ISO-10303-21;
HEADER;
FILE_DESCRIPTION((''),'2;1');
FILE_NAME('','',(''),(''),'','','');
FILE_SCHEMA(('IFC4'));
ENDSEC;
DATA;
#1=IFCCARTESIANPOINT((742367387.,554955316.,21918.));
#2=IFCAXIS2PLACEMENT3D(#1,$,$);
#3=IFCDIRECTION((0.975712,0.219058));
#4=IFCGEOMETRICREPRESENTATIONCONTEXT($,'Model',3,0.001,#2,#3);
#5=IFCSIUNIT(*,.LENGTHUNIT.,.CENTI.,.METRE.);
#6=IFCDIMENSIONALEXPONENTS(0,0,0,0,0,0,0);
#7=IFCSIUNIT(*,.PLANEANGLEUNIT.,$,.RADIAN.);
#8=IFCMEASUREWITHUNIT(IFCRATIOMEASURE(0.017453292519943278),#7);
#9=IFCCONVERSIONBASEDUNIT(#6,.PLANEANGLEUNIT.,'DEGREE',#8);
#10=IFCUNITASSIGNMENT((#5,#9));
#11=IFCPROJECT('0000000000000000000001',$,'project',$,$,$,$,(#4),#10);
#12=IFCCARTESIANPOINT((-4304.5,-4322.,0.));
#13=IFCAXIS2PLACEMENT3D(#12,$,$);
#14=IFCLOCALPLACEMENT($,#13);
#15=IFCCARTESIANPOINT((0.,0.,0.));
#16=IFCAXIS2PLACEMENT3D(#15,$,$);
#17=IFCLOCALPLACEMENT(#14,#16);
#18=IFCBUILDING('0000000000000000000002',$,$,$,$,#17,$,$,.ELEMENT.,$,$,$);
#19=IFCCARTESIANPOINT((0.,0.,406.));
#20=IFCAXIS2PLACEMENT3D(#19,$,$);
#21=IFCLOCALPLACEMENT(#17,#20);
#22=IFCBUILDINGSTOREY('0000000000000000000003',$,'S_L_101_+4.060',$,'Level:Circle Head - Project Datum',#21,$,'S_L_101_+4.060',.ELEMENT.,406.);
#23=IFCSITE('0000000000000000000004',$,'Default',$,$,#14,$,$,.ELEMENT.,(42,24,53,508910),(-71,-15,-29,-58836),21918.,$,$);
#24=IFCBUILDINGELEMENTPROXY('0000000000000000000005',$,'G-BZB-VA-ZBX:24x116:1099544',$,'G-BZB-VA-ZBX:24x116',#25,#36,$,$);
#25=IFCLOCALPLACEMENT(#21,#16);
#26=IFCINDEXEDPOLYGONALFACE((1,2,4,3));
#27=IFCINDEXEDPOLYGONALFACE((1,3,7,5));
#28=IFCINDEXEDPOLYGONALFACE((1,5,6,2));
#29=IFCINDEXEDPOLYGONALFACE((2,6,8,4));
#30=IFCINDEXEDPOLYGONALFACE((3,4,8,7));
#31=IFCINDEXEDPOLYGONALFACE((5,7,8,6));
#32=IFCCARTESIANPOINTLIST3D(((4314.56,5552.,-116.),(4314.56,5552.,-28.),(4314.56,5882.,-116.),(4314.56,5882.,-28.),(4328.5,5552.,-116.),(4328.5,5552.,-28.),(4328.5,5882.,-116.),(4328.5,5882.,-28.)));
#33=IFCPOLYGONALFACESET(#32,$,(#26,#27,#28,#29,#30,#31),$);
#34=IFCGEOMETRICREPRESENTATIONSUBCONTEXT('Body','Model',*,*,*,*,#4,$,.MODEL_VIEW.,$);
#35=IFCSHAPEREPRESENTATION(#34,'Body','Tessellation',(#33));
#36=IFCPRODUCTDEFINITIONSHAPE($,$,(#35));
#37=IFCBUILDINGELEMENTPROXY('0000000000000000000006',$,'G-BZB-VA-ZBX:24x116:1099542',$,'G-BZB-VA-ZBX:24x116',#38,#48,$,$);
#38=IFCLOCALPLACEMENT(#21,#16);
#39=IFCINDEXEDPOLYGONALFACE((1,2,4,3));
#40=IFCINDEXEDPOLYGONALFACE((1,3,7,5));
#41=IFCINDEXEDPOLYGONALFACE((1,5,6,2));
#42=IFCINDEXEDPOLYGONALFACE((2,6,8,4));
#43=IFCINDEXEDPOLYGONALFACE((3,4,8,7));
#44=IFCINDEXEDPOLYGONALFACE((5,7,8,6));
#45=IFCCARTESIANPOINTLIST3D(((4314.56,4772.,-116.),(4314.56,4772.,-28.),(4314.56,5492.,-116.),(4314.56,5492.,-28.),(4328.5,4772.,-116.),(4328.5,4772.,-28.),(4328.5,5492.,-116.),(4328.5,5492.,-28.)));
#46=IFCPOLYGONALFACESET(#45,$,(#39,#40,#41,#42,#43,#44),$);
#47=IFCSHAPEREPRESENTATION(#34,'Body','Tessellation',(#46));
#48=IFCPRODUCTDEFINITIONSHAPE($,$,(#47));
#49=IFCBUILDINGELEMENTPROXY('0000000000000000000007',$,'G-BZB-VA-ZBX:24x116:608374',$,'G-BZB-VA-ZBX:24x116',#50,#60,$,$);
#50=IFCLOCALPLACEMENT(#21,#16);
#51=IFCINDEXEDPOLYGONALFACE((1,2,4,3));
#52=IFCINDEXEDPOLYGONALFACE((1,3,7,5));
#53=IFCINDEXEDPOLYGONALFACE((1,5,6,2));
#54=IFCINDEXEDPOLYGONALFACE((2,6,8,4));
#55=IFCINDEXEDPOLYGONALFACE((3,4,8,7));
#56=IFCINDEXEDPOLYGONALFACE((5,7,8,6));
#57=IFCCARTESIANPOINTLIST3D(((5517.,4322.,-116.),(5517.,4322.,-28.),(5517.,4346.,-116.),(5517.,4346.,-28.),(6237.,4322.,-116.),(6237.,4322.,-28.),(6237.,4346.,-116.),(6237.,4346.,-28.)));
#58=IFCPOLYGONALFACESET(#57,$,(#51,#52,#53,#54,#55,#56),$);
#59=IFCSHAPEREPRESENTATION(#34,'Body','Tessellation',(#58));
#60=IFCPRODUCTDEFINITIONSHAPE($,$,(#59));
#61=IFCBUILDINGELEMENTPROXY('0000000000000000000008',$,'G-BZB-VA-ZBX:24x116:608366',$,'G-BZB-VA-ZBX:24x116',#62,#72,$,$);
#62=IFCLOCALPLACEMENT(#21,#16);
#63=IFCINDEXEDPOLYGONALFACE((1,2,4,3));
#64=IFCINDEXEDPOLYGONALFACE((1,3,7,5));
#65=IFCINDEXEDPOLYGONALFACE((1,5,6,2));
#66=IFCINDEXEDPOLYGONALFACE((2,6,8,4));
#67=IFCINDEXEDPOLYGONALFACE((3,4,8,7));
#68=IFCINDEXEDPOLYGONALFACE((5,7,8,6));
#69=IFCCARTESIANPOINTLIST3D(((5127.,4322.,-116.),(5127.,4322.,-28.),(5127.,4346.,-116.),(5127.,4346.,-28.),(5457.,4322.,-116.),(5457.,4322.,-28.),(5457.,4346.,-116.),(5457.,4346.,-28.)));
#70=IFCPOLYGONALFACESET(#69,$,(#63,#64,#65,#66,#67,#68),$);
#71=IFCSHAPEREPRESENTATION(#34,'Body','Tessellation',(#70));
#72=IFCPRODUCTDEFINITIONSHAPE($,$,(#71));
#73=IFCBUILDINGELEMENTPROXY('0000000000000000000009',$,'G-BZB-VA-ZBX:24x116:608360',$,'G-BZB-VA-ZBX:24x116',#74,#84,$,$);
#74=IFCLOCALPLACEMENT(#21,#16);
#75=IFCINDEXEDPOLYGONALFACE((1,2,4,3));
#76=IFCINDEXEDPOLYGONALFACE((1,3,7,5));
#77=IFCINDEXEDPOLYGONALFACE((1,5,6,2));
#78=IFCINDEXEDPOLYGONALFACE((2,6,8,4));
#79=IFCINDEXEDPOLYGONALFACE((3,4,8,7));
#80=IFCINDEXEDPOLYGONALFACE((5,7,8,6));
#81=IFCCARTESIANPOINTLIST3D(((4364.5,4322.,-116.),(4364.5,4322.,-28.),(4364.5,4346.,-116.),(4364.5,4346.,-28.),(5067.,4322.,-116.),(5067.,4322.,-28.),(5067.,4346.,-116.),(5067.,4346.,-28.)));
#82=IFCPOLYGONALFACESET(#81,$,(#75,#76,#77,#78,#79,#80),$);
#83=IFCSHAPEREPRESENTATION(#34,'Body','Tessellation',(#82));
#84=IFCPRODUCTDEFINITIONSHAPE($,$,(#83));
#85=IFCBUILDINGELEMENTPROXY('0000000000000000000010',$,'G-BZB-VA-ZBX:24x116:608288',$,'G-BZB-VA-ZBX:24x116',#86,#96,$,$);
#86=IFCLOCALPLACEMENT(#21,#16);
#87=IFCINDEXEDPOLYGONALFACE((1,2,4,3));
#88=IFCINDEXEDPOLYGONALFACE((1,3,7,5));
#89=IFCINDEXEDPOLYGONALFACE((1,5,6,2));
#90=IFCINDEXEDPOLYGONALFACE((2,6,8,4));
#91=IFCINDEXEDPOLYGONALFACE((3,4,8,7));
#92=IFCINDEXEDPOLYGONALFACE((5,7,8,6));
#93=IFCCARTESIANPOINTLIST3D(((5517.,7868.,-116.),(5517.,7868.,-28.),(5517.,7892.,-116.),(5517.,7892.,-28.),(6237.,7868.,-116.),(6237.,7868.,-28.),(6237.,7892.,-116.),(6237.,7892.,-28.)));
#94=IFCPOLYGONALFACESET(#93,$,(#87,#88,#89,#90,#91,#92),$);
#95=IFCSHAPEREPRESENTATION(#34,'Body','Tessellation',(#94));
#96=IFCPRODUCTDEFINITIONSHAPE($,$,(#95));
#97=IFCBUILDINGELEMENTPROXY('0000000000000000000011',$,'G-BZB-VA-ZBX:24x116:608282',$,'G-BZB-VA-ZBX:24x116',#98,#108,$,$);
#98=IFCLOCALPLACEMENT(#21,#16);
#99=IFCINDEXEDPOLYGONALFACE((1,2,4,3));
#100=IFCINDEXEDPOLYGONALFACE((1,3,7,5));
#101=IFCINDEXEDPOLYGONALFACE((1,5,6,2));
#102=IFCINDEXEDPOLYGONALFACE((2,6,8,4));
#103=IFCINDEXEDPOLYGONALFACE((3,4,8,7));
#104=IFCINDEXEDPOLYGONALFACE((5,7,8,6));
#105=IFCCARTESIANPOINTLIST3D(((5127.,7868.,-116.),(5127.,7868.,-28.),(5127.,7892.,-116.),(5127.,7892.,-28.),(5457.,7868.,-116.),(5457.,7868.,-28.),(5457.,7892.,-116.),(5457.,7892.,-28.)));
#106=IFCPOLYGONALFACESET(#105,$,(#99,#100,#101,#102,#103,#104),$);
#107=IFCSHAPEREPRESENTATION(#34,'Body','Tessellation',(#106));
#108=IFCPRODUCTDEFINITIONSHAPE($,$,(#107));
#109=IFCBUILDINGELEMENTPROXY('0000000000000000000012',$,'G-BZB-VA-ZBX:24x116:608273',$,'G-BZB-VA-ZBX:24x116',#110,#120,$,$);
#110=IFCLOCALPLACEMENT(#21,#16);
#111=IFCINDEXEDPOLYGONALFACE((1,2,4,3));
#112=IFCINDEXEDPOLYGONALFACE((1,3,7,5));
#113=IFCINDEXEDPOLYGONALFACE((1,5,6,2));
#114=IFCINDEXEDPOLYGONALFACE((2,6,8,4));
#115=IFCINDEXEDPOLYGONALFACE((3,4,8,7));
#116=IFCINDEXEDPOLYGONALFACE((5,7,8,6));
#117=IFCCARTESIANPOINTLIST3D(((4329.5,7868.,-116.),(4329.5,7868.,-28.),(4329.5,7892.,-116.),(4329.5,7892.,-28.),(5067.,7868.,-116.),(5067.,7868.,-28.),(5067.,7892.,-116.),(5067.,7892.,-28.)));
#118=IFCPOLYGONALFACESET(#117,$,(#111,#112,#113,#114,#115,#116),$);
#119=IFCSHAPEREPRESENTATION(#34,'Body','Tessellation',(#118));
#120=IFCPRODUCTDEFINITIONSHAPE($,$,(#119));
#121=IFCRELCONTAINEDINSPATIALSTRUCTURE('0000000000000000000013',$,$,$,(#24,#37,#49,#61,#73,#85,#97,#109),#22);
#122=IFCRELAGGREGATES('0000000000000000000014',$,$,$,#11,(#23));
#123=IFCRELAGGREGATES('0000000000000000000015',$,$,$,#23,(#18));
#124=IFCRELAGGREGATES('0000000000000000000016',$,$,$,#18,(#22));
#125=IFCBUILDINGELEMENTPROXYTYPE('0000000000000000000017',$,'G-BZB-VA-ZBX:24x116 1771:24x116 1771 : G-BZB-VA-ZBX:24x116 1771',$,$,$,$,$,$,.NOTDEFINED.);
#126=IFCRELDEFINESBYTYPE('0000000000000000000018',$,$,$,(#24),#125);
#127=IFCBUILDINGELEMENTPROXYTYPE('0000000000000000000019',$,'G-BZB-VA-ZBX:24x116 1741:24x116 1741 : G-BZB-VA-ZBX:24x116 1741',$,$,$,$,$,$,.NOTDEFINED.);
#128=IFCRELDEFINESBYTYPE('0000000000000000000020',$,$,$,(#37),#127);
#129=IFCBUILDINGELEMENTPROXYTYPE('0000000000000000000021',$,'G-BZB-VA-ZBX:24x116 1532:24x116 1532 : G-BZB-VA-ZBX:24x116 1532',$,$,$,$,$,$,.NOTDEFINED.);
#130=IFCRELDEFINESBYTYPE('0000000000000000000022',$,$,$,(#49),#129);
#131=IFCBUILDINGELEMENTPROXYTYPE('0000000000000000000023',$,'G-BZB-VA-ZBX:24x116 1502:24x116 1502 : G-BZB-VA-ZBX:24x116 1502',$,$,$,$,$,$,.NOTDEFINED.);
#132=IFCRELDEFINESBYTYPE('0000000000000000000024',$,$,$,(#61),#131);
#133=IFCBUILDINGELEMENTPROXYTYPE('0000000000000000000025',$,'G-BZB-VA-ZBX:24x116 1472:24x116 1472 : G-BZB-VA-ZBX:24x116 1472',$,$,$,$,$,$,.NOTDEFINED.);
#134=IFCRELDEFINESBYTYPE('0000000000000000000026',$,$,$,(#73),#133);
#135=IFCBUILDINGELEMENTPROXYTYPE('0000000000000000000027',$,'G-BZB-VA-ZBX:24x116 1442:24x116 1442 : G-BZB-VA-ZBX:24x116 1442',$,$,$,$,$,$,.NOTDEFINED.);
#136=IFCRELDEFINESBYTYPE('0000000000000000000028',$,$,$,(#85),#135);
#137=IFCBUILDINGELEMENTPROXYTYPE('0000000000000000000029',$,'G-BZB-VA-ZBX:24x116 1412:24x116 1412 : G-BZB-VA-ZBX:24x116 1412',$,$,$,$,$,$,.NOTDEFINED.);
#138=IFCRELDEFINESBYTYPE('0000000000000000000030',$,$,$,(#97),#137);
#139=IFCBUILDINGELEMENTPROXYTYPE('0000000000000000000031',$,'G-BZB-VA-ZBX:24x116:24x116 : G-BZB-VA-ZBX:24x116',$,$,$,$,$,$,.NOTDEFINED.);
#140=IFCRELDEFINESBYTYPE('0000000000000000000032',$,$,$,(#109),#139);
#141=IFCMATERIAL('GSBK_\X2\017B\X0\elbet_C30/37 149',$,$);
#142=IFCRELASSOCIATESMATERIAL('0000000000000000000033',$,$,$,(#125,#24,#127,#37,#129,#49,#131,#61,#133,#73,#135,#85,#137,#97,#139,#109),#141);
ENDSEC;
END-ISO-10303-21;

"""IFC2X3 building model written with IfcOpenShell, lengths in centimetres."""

from ifc_helpers import new_model, entity, si_unit, converted_unit, direction, frame, frame_2d, origin, origin_2d_with_axis, place, context, subcontext, project, spatial, rectangle, extrude, source, transform, mapped, material, type_object, type_shapes, element, save


model = new_model("IFC2X3")

# Units and contexts
model_context = context("Model", 3, precision=0.001, world=frame((742367387.0, 554955316.0, 21918.0)), true_north=direction((0.975712, 0.219058)))
body_context = subcontext(model_context, "Body", "Model", "MODEL_VIEW")
ifc_project = project(units=[si_unit("LENGTHUNIT", "METRE", prefix="CENTI"), converted_unit("PLANEANGLEUNIT", "DEGREE", entity("IfcRatioMeasure", 0.017453292519943278), si_unit("PLANEANGLEUNIT", "RADIAN"), dimensions=[0, 0, 0, 0, 0, 0, 0])], contexts=[model_context])

# Site, building, storey
site_placement = place(None, frame((-4304.5, -4322.0, 0.0)))
site = spatial("IfcSite", under=ifc_project, at=site_placement, Name="Default", CompositionType="ELEMENT", RefLatitude=(42, 24, 53, 508910), RefLongitude=(-71, -15, -29, -58836), RefElevation=21918.0)
building_placement = place(site_placement, origin())
building = spatial("IfcBuilding", under=site, at=building_placement, CompositionType="ELEMENT")
storey_placement = place(building_placement, frame((0.0, 0.0, 406.0)))
storey = spatial("IfcBuildingStorey", under=building, at=storey_placement, Name="S_L_101_+4.060", ObjectType="Level:Circle Head - Project Datum", LongName="S_L_101_+4.060", CompositionType="ELEMENT", Elevation=406.0)

# Building element proxies
ifc_material_1 = material(Name="GSBK_Żelbet_C30/37 149")
building_element_proxy_type_1 = type_object("IfcBuildingElementProxyType", Name="G-BZB-VA-ZBX:24x116 1771:24x116 1771 : G-BZB-VA-ZBX:24x116 1771", PredefinedType="NOTDEFINED", material=ifc_material_1)
shared_shape_1 = source(origin(), body_context, "Body", "SweptSolid", [
    extrude(rectangle(XDim=330.0, YDim=13.94, at=origin_2d_with_axis()), frame((165.0, 6.97, 0.0), z_axis=(0.0, 0.0, 1.0), x_axis=(-1.0, 0.0, 0.0)), (0.0, 0.0, 1.0), 88.0),
])
type_shapes(building_element_proxy_type_1, [shared_shape_1])
proxy_1_placement = place(storey_placement, frame((4328.5, 5552.0, -116.0), z_axis=(0.0, 0.0, 1.0), x_axis=(0.0, 1.0, 0.0)))
element("IfcBuildingElementProxy", 1, at=proxy_1_placement, inside=storey, type_object=building_element_proxy_type_1, material=ifc_material_1, Name="G-BZB-VA-ZBX:24x116:1099544", ObjectType="G-BZB-VA-ZBX:24x116", context=body_context, shape_type="MappedRepresentation", body=[
    mapped(shared_shape_1, transform((0.0, 0.0, 0.0), scale=1.0)),
])
building_element_proxy_type_2 = type_object("IfcBuildingElementProxyType", Name="G-BZB-VA-ZBX:24x116 1741:24x116 1741 : G-BZB-VA-ZBX:24x116 1741", PredefinedType="NOTDEFINED", material=ifc_material_1)
shared_shape_2 = source(origin(), body_context, "Body", "SweptSolid", [
    extrude(rectangle(XDim=720.0, YDim=13.94, at=origin_2d_with_axis()), frame((360.0, 6.97, 0.0), z_axis=(0.0, 0.0, 1.0), x_axis=(-1.0, 0.0, 0.0)), (0.0, 0.0, 1.0), 88.0),
])
type_shapes(building_element_proxy_type_2, [shared_shape_2])
proxy_2_placement = place(storey_placement, frame((4328.5, 4772.0, -116.0), z_axis=(0.0, 0.0, 1.0), x_axis=(0.0, 1.0, 0.0)))
element("IfcBuildingElementProxy", 2, at=proxy_2_placement, inside=storey, type_object=building_element_proxy_type_2, material=ifc_material_1, Name="G-BZB-VA-ZBX:24x116:1099542", ObjectType="G-BZB-VA-ZBX:24x116", context=body_context, shape_type="MappedRepresentation", body=[
    mapped(shared_shape_2, transform((0.0, 0.0, 0.0), scale=1.0)),
])
building_element_proxy_type_3 = type_object("IfcBuildingElementProxyType", Name="G-BZB-VA-ZBX:24x116 1532:24x116 1532 : G-BZB-VA-ZBX:24x116 1532", PredefinedType="NOTDEFINED", material=ifc_material_1)
shared_shape_3 = source(origin(), body_context, "Body", "SweptSolid", [
    extrude(rectangle(XDim=720.0, YDim=24.0, at=origin_2d_with_axis()), frame((360.0, 12.0, 0.0), z_axis=(0.0, 0.0, 1.0), x_axis=(-1.0, 0.0, 0.0)), (0.0, 0.0, 1.0), 88.0),
])
type_shapes(building_element_proxy_type_3, [shared_shape_3])
proxy_3_placement = place(storey_placement, frame((5517.0, 4322.0, -116.0)))
element("IfcBuildingElementProxy", 3, at=proxy_3_placement, inside=storey, type_object=building_element_proxy_type_3, material=ifc_material_1, Name="G-BZB-VA-ZBX:24x116:608374", ObjectType="G-BZB-VA-ZBX:24x116", context=body_context, shape_type="MappedRepresentation", body=[
    mapped(shared_shape_3, transform((0.0, 0.0, 0.0), scale=1.0)),
])
building_element_proxy_type_4 = type_object("IfcBuildingElementProxyType", Name="G-BZB-VA-ZBX:24x116 1502:24x116 1502 : G-BZB-VA-ZBX:24x116 1502", PredefinedType="NOTDEFINED", material=ifc_material_1)
shared_shape_4 = source(origin(), body_context, "Body", "SweptSolid", [
    extrude(rectangle(XDim=330.0, YDim=24.0, at=origin_2d_with_axis()), frame((165.0, 12.0, 0.0), z_axis=(0.0, 0.0, 1.0), x_axis=(-1.0, 0.0, 0.0)), (0.0, 0.0, 1.0), 88.0),
])
type_shapes(building_element_proxy_type_4, [shared_shape_4])
proxy_4_placement = place(storey_placement, frame((5127.0, 4322.0, -116.0)))
element("IfcBuildingElementProxy", 4, at=proxy_4_placement, inside=storey, type_object=building_element_proxy_type_4, material=ifc_material_1, Name="G-BZB-VA-ZBX:24x116:608366", ObjectType="G-BZB-VA-ZBX:24x116", context=body_context, shape_type="MappedRepresentation", body=[
    mapped(shared_shape_4, transform((0.0, 0.0, 0.0), scale=1.0)),
])
building_element_proxy_type_5 = type_object("IfcBuildingElementProxyType", Name="G-BZB-VA-ZBX:24x116 1472:24x116 1472 : G-BZB-VA-ZBX:24x116 1472", PredefinedType="NOTDEFINED", material=ifc_material_1)
shared_shape_5 = source(origin(), body_context, "Body", "SweptSolid", [
    extrude(rectangle(XDim=702.5, YDim=24.0, at=origin_2d_with_axis()), frame((351.25, 12.0, 0.0), z_axis=(0.0, 0.0, 1.0), x_axis=(-1.0, 0.0, 0.0)), (0.0, 0.0, 1.0), 88.0),
])
type_shapes(building_element_proxy_type_5, [shared_shape_5])
proxy_5_placement = place(storey_placement, frame((4364.5, 4322.0, -116.0)))
element("IfcBuildingElementProxy", 5, at=proxy_5_placement, inside=storey, type_object=building_element_proxy_type_5, material=ifc_material_1, Name="G-BZB-VA-ZBX:24x116:608360", ObjectType="G-BZB-VA-ZBX:24x116", context=body_context, shape_type="MappedRepresentation", body=[
    mapped(shared_shape_5, transform((0.0, 0.0, 0.0), scale=1.0)),
])
building_element_proxy_type_6 = type_object("IfcBuildingElementProxyType", Name="G-BZB-VA-ZBX:24x116 1442:24x116 1442 : G-BZB-VA-ZBX:24x116 1442", PredefinedType="NOTDEFINED", material=ifc_material_1)
shared_shape_6 = source(origin(), body_context, "Body", "SweptSolid", [
    extrude(rectangle(XDim=720.0, YDim=24.0, at=frame_2d((0.0, 0.0), x_axis=(1.0, 0.0))), frame((360.0, 12.0, 0.0), z_axis=(0.0, 0.0, 1.0), x_axis=(-1.0, 0.0, 0.0)), (0.0, 0.0, 1.0), 88.0),
])
type_shapes(building_element_proxy_type_6, [shared_shape_6])
proxy_6_placement = place(storey_placement, frame((5517.0, 7868.0, -116.0)))
element("IfcBuildingElementProxy", 6, at=proxy_6_placement, inside=storey, type_object=building_element_proxy_type_6, material=ifc_material_1, Name="G-BZB-VA-ZBX:24x116:608288", ObjectType="G-BZB-VA-ZBX:24x116", context=body_context, shape_type="MappedRepresentation", body=[
    mapped(shared_shape_6, transform((0.0, 0.0, 0.0), scale=1.0)),
])
building_element_proxy_type_7 = type_object("IfcBuildingElementProxyType", Name="G-BZB-VA-ZBX:24x116 1412:24x116 1412 : G-BZB-VA-ZBX:24x116 1412", PredefinedType="NOTDEFINED", material=ifc_material_1)
shared_shape_7 = source(origin(), body_context, "Body", "SweptSolid", [
    extrude(rectangle(XDim=330.0, YDim=24.0, at=frame_2d((0.0, 0.0), x_axis=(1.0, 0.0))), frame((165.0, 12.0, 0.0), z_axis=(0.0, 0.0, 1.0), x_axis=(-1.0, 0.0, 0.0)), (0.0, 0.0, 1.0), 88.0),
])
type_shapes(building_element_proxy_type_7, [shared_shape_7])
proxy_7_placement = place(storey_placement, frame((5127.0, 7868.0, -116.0)))
element("IfcBuildingElementProxy", 7, at=proxy_7_placement, inside=storey, type_object=building_element_proxy_type_7, material=ifc_material_1, Name="G-BZB-VA-ZBX:24x116:608282", ObjectType="G-BZB-VA-ZBX:24x116", context=body_context, shape_type="MappedRepresentation", body=[
    mapped(shared_shape_7, transform((0.0, 0.0, 0.0), scale=1.0)),
])
building_element_proxy_type_8 = type_object("IfcBuildingElementProxyType", Name="G-BZB-VA-ZBX:24x116:24x116 : G-BZB-VA-ZBX:24x116", PredefinedType="NOTDEFINED", material=ifc_material_1)
shared_shape_8 = source(origin(), body_context, "Body", "SweptSolid", [
    extrude(rectangle(XDim=737.5, YDim=24.0, at=frame_2d((0.0, 0.0), x_axis=(1.0, 0.0))), frame((368.75, 12.0, 0.0), z_axis=(0.0, 0.0, 1.0), x_axis=(-1.0, 0.0, 0.0)), (0.0, 0.0, 1.0), 88.0),
])
type_shapes(building_element_proxy_type_8, [shared_shape_8])
proxy_8_placement = place(storey_placement, frame((4329.5, 7868.0, -116.0)))
element("IfcBuildingElementProxy", 8, at=proxy_8_placement, inside=storey, type_object=building_element_proxy_type_8, material=ifc_material_1, Name="G-BZB-VA-ZBX:24x116:608273", ObjectType="G-BZB-VA-ZBX:24x116", context=body_context, shape_type="MappedRepresentation", body=[
    mapped(shared_shape_8, transform((0.0, 0.0, 0.0), scale=1.0)),
])

save(model, "model.ifc")
